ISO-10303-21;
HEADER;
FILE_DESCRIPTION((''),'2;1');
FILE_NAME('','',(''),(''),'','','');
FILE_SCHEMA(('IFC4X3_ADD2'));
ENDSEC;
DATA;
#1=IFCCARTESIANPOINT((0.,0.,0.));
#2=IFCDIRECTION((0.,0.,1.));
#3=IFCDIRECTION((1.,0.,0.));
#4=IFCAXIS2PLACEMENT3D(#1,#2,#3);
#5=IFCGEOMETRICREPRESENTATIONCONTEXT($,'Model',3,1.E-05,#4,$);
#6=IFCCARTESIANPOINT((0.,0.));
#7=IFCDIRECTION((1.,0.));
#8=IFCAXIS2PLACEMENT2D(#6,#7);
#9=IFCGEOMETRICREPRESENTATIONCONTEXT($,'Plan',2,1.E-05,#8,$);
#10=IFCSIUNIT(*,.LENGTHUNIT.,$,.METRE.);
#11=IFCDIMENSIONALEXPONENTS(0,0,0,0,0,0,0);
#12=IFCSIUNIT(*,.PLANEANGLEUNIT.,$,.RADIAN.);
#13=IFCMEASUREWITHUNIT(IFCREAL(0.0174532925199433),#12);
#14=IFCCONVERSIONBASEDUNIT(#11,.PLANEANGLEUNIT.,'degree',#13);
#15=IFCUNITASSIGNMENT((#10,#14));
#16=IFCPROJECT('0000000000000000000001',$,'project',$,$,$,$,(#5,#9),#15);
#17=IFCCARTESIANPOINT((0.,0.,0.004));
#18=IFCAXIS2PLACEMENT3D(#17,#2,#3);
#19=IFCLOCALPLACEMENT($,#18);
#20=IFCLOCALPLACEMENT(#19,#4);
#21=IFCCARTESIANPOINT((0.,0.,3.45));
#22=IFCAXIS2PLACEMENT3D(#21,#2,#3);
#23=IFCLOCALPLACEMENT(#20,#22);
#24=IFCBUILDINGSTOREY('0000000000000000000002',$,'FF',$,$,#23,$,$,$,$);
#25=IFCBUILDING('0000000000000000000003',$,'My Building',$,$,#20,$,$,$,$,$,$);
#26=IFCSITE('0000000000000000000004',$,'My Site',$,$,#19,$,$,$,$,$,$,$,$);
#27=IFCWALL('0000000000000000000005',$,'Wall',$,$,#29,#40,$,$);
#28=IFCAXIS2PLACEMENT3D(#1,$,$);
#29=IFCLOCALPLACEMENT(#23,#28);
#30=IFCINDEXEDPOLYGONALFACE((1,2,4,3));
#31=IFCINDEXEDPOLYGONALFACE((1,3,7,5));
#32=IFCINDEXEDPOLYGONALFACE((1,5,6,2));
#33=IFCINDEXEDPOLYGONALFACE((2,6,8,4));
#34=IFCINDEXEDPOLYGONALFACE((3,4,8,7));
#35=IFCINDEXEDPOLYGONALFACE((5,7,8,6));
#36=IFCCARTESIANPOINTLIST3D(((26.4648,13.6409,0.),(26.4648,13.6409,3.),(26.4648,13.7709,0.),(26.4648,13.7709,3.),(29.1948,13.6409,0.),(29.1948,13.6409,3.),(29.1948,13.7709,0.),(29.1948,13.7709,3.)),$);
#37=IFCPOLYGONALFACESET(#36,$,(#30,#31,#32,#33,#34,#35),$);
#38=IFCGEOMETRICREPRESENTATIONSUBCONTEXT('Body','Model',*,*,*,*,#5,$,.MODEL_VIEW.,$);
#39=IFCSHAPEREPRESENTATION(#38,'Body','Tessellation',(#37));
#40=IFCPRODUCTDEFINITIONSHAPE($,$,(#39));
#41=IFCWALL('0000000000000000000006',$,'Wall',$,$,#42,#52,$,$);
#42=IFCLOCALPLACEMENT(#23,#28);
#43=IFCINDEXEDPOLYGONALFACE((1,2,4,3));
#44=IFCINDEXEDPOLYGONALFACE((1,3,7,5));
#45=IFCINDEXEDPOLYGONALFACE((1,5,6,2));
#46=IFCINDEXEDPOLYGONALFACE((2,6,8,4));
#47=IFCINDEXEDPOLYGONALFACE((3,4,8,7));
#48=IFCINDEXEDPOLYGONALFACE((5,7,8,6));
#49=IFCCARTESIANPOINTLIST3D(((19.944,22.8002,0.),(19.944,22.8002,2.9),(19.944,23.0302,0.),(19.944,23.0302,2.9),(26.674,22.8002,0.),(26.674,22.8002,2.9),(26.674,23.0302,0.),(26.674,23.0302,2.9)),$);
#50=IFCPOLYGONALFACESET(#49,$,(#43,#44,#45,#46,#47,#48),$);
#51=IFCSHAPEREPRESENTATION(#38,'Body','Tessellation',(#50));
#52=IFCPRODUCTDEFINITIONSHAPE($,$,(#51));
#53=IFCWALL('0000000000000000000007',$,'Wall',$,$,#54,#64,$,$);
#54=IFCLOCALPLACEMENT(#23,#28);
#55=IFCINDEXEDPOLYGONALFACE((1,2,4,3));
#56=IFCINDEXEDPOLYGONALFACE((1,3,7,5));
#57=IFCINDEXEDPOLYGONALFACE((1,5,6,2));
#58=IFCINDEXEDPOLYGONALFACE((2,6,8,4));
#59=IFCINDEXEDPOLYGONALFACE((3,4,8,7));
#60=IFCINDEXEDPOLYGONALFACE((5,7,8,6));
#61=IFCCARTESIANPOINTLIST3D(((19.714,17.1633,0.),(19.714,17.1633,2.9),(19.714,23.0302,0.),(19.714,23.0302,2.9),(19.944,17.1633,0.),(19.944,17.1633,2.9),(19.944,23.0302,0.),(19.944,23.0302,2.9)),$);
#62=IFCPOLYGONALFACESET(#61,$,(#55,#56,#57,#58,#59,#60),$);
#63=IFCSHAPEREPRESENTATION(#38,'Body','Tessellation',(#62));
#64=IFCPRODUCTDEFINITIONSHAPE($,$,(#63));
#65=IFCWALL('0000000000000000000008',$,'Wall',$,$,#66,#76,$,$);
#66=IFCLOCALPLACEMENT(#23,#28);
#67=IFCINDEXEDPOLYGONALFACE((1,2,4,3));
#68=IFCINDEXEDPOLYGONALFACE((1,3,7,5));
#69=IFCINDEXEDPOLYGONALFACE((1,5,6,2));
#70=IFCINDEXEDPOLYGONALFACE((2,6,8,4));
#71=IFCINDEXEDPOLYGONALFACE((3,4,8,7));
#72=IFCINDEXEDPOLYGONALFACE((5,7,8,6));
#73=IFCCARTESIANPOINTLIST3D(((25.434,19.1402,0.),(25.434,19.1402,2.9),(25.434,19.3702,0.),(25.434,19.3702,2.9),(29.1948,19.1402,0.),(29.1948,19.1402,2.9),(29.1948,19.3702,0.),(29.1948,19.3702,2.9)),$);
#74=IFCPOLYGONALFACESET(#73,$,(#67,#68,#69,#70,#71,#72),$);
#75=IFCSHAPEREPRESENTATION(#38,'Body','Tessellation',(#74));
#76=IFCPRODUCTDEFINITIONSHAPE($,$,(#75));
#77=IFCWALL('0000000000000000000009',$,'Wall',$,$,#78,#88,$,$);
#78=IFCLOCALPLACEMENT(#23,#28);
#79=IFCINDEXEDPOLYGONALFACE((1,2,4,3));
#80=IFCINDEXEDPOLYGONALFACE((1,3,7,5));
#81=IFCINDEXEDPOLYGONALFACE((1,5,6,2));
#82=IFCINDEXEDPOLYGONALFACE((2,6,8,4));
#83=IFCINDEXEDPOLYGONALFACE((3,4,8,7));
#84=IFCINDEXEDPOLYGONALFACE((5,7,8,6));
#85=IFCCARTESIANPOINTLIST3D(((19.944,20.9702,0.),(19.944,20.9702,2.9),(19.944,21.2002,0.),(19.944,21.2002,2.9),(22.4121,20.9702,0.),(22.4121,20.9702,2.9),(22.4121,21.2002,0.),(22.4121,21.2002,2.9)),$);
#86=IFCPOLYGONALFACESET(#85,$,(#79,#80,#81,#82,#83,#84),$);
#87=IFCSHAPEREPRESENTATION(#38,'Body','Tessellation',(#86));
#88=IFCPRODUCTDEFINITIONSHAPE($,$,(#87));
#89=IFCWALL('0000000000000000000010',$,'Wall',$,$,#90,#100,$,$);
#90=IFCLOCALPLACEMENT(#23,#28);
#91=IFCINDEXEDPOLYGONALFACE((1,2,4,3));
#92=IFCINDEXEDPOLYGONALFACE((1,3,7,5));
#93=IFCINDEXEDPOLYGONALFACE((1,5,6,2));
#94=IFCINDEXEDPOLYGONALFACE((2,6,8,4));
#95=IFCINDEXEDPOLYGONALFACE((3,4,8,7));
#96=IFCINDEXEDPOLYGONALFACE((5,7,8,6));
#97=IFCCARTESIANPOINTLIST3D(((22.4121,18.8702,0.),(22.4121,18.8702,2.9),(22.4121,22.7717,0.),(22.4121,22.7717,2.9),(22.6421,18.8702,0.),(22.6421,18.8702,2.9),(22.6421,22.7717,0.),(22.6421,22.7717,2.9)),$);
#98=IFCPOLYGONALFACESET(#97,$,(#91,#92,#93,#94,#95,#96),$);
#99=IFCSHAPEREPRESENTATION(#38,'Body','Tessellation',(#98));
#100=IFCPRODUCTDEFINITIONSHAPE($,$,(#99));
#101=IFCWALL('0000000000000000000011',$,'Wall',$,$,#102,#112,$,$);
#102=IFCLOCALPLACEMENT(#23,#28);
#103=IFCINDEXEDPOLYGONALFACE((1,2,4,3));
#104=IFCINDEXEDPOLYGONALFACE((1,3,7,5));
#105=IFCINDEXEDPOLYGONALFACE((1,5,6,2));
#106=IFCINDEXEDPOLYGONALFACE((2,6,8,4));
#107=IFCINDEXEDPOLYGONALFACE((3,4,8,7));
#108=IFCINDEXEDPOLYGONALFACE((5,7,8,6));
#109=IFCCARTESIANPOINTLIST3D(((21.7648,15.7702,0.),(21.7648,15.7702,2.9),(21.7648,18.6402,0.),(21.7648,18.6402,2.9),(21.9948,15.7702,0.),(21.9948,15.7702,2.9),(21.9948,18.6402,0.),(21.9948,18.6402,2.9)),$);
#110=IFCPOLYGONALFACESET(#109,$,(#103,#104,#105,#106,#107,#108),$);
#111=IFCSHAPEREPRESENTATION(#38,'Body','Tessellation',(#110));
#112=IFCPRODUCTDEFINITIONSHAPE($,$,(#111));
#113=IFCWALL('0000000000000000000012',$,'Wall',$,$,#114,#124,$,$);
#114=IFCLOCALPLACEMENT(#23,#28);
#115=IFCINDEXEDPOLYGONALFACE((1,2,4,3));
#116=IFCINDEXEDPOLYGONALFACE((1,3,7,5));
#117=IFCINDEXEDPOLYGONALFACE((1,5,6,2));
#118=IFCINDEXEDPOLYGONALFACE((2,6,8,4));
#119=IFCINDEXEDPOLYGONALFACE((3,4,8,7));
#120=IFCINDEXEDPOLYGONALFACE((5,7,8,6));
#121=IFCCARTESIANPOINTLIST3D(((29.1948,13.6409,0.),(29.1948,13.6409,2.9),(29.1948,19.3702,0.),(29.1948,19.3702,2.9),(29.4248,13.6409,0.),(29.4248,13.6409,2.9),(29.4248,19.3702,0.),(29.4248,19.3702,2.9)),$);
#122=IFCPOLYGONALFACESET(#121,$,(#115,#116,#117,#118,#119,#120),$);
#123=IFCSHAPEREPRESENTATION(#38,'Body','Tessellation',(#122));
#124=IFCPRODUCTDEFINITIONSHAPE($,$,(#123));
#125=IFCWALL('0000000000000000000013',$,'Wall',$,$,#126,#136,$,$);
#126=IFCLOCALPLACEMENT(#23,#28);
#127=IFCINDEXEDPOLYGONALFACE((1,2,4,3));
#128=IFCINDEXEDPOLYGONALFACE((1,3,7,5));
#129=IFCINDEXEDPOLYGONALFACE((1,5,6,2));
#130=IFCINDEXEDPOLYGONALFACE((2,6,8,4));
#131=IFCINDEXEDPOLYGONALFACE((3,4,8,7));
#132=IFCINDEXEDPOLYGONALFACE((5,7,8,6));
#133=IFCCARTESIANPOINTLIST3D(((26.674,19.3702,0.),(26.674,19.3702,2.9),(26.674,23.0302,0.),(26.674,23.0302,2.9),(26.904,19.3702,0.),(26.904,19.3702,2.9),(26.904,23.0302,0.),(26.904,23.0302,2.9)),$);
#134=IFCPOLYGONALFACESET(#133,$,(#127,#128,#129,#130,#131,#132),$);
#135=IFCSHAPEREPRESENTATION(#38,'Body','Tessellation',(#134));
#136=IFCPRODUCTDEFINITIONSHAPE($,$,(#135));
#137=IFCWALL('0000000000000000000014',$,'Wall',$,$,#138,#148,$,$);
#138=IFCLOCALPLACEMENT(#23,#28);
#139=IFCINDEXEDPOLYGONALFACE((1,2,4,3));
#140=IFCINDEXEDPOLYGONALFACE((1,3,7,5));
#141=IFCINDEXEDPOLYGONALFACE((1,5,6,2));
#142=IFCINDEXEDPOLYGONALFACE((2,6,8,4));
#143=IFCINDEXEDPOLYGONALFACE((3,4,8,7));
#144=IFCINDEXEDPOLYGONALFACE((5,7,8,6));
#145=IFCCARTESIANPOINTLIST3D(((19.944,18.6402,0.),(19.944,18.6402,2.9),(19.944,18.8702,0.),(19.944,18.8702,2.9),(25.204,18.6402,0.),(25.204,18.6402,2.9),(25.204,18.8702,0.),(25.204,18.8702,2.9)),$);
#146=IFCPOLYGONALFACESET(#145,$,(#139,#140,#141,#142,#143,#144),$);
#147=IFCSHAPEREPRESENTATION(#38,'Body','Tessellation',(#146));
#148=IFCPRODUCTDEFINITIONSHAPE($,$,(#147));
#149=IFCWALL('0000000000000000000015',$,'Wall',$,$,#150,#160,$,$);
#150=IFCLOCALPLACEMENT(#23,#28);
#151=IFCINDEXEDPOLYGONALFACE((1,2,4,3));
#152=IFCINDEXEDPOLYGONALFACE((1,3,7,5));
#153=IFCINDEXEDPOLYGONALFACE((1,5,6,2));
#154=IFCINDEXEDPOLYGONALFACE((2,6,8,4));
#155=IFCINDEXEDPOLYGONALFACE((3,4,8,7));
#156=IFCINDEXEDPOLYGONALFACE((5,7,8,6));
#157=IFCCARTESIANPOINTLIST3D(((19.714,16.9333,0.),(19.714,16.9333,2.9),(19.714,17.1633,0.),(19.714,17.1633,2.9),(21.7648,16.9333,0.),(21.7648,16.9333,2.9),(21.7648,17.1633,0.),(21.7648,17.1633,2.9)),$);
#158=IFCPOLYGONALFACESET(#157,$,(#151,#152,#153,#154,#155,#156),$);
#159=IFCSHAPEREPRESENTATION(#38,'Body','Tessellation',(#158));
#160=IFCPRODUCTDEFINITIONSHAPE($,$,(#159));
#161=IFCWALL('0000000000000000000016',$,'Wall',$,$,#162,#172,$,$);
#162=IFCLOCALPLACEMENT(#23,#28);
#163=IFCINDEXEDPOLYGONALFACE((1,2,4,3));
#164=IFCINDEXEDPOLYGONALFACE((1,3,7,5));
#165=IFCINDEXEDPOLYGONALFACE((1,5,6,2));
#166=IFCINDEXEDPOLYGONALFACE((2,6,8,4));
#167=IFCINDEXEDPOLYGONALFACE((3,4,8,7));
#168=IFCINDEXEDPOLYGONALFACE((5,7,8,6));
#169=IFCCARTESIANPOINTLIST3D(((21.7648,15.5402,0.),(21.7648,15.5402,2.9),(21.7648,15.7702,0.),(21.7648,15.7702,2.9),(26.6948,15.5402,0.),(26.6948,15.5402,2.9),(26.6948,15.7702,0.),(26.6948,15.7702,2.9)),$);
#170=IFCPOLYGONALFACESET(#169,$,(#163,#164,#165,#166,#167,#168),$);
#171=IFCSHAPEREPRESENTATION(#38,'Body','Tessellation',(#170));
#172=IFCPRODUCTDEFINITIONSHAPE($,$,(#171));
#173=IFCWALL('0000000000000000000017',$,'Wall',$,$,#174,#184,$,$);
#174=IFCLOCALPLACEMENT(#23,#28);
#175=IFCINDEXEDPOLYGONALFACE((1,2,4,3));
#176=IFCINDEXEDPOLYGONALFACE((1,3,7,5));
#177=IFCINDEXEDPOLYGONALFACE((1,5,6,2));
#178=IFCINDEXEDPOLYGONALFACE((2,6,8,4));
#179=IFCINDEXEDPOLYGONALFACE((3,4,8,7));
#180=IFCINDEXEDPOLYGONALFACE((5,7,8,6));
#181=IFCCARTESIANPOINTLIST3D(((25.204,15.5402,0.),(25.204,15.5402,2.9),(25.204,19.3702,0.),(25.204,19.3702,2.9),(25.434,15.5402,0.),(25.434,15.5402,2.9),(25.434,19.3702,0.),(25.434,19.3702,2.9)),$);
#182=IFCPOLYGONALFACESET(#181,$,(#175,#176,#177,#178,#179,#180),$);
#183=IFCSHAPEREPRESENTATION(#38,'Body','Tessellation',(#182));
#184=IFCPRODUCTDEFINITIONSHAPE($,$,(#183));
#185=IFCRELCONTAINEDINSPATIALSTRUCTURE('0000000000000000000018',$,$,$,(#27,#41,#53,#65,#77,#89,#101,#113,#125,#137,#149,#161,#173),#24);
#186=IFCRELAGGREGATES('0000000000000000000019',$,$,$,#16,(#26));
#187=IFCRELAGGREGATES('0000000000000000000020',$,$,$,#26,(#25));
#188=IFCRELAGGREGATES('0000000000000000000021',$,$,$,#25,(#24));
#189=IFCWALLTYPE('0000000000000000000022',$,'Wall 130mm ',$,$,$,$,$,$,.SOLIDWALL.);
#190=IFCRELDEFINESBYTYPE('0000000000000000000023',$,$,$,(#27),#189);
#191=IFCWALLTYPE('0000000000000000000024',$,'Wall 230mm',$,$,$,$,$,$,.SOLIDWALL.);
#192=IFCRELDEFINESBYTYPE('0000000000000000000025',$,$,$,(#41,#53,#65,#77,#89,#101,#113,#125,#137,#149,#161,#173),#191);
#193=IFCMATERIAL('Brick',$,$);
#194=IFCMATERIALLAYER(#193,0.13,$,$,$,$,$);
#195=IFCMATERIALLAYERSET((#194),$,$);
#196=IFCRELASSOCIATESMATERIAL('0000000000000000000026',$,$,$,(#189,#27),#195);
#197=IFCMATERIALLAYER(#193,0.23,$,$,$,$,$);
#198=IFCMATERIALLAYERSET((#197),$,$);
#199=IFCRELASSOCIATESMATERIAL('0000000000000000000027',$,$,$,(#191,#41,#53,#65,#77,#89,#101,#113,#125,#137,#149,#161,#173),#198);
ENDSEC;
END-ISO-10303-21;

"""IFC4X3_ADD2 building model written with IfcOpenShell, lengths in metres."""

from ifc_helpers import new_model, entity, si_unit, converted_unit, frame, origin_with_axes, origin_2d_with_axis, place, context, subcontext, project, spatial, indexed_curve, outline, extrude, material, layer, layer_set, layer_usage, type_object, element, save


model = new_model("IFC4X3_ADD2")

# Units and contexts
model_context = context("Model", 3, precision=1e-05, world=origin_with_axes())
plan_context = context("Plan", 2, precision=1e-05, world=origin_2d_with_axis())
body_context = subcontext(model_context, "Body", "Model", "MODEL_VIEW")
ifc_project = project(units=[si_unit("LENGTHUNIT", "METRE"), converted_unit("PLANEANGLEUNIT", "degree", entity("IfcReal", 0.0174532925199433), si_unit("PLANEANGLEUNIT", "RADIAN"), dimensions=[0, 0, 0, 0, 0, 0, 0])], contexts=[model_context, plan_context])

# Site, building, storey
site_placement = place(None, frame((0.0, 0.0, 0.004), z_axis=(0.0, 0.0, 1.0), x_axis=(1.0, 0.0, 0.0)))
site = spatial("IfcSite", under=ifc_project, at=site_placement, Name="My Site")
building_placement = place(site_placement, origin_with_axes())
building = spatial("IfcBuilding", under=site, at=building_placement, Name="My Building")
storey_placement = place(building_placement, frame((0.0, 0.0, 3.45), z_axis=(0.0, 0.0, 1.0), x_axis=(1.0, 0.0, 0.0)))
storey = spatial("IfcBuildingStorey", under=building, at=storey_placement, Name="FF")

# Walls
ifc_material = material(Name="Brick")
ifc_layer_1 = layer(ifc_material, 0.13)
ifc_layer_set_1 = layer_set([ifc_layer_1])
ifc_layer_usage_1 = layer_usage(ifc_layer_set_1, "AXIS2", "POSITIVE", 0.0)
wall_type_1 = type_object("IfcWallType", Name="Wall 130mm ", PredefinedType="SOLIDWALL", material=ifc_layer_set_1)
wall_1_placement = place(storey_placement, frame((29.1948, 13.7709, 0.0), z_axis=(0.0, 0.0, 1.0), x_axis=(-1.0, 0.0, 0.0)))
element("IfcWall", 1, at=wall_1_placement, inside=storey, type_object=wall_type_1, material=ifc_layer_usage_1, Name="Wall", context=body_context, shape_type="SweptSolid", body=[
    extrude(outline(indexed_curve([(0.0, 0.0), (0.0, 0.13), (2.73, 0.13), (2.73, 0.0), (0.0, 0.0)], self_intersect=False)), origin_with_axes(), (0.0, 0.0, 1.0), 3.0),
])
ifc_layer_2 = layer(ifc_material, 0.23)
ifc_layer_set_2 = layer_set([ifc_layer_2])
ifc_layer_usage_2 = layer_usage(ifc_layer_set_2, "AXIS2", "POSITIVE", 0.0)
wall_type_2 = type_object("IfcWallType", Name="Wall 230mm", PredefinedType="SOLIDWALL", material=ifc_layer_set_2)
wall_2_placement = place(storey_placement, frame((26.674, 23.0302, 0.0), z_axis=(0.0, 0.0, 1.0), x_axis=(-1.0, 0.0, 0.0)))
element("IfcWall", 2, at=wall_2_placement, inside=storey, type_object=wall_type_2, material=ifc_layer_usage_2, Name="Wall", context=body_context, shape_type="SweptSolid", body=[
    extrude(outline(indexed_curve([(0.0, 0.0), (0.0, 0.23), (6.73, 0.23), (6.73, 0.0), (0.0, 0.0)], self_intersect=False)), origin_with_axes(), (0.0, 0.0, 1.0), 2.9),
])
ifc_layer_usage_3 = layer_usage(ifc_layer_set_2, "AXIS2", "POSITIVE", 0.0)
wall_3_placement = place(storey_placement, frame((19.944, 17.1633, 0.0), z_axis=(0.0, 0.0, 1.0), x_axis=(0.000001, 1.0, 0.0)))
element("IfcWall", 3, at=wall_3_placement, inside=storey, type_object=wall_type_2, material=ifc_layer_usage_3, Name="Wall", context=body_context, shape_type="SweptSolid", body=[
    extrude(outline(indexed_curve([(0.0, 0.0), (0.0, 0.23), (5.8669, 0.23), (5.8669, 0.0), (0.0, 0.0)], self_intersect=False)), origin_with_axes(), (0.0, 0.0, 1.0), 2.9),
])
ifc_layer_usage_4 = layer_usage(ifc_layer_set_2, "AXIS2", "POSITIVE", 0.0)
wall_4_placement = place(storey_placement, frame((29.1948, 19.3702, 0.0), z_axis=(0.0, 0.0, 1.0), x_axis=(-1.0, 0.0, 0.0)))
element("IfcWall", 4, at=wall_4_placement, inside=storey, type_object=wall_type_2, material=ifc_layer_usage_4, Name="Wall", context=body_context, shape_type="SweptSolid", body=[
    extrude(outline(indexed_curve([(0.0, 0.0), (0.0, 0.23), (3.7608, 0.23), (3.7608, 0.0), (0.0, 0.0)], self_intersect=False)), origin_with_axes(), (0.0, 0.0, 1.0), 2.9),
])
ifc_layer_usage_5 = layer_usage(ifc_layer_set_2, "AXIS2", "POSITIVE", 0.0)
wall_5_placement = place(storey_placement, frame((22.4121, 21.2002, 0.0), z_axis=(0.0, 0.0, 1.0), x_axis=(-1.0, 0.0, 0.0)))
element("IfcWall", 5, at=wall_5_placement, inside=storey, type_object=wall_type_2, material=ifc_layer_usage_5, Name="Wall", context=body_context, shape_type="SweptSolid", body=[
    extrude(outline(indexed_curve([(0.0, 0.0), (0.0, 0.23), (2.4681, 0.23), (2.4681, 0.0), (0.0, 0.0)], self_intersect=False)), origin_with_axes(), (0.0, 0.0, 1.0), 2.9),
])
ifc_layer_usage_6 = layer_usage(ifc_layer_set_2, "AXIS2", "POSITIVE", 0.0)
wall_6_placement = place(storey_placement, frame((22.6421, 18.8702, 0.0), z_axis=(0.0, 0.0, 1.0), x_axis=(0.000001, 1.0, 0.0)))
element("IfcWall", 6, at=wall_6_placement, inside=storey, type_object=wall_type_2, material=ifc_layer_usage_6, Name="Wall", context=body_context, shape_type="SweptSolid", body=[
    extrude(outline(indexed_curve([(0.0, 0.0), (0.0, 0.23), (3.9015, 0.23), (3.9015, 0.0), (0.0, 0.0)], self_intersect=False)), origin_with_axes(), (0.0, 0.0, 1.0), 2.9),
])
ifc_layer_usage_7 = layer_usage(ifc_layer_set_2, "AXIS2", "POSITIVE", 0.0)
wall_7_placement = place(storey_placement, frame((21.9948, 15.7702, 0.0), z_axis=(0.0, 0.0, 1.0), x_axis=(0.000001, 1.0, 0.0)))
element("IfcWall", 7, at=wall_7_placement, inside=storey, type_object=wall_type_2, material=ifc_layer_usage_7, Name="Wall", context=body_context, shape_type="SweptSolid", body=[
    extrude(outline(indexed_curve([(0.0, 0.0), (0.0, 0.23), (2.87, 0.23), (2.87, 0.0), (0.0, 0.0)], self_intersect=False)), origin_with_axes(), (0.0, 0.0, 1.0), 2.9),
])
ifc_layer_usage_8 = layer_usage(ifc_layer_set_2, "AXIS2", "POSITIVE", 0.0)
wall_8_placement = place(storey_placement, frame((29.4248, 13.6409, 0.0), z_axis=(0.0, 0.0, 1.0), x_axis=(0.000001, 1.0, 0.0)))
element("IfcWall", 8, at=wall_8_placement, inside=storey, type_object=wall_type_2, material=ifc_layer_usage_8, Name="Wall", context=body_context, shape_type="SweptSolid", body=[
    extrude(outline(indexed_curve([(0.0, 0.0), (0.0, 0.23), (5.7293, 0.23), (5.7293, 0.0), (0.0, 0.0)], self_intersect=False)), origin_with_axes(), (0.0, 0.0, 1.0), 2.9),
])
ifc_layer_usage_9 = layer_usage(ifc_layer_set_2, "AXIS2", "POSITIVE", 0.0)
wall_9_placement = place(storey_placement, frame((26.904, 19.3702, 0.0), z_axis=(0.0, 0.0, 1.0), x_axis=(0.000001, 1.0, 0.0)))
element("IfcWall", 9, at=wall_9_placement, inside=storey, type_object=wall_type_2, material=ifc_layer_usage_9, Name="Wall", context=body_context, shape_type="SweptSolid", body=[
    extrude(outline(indexed_curve([(0.0, 0.0), (0.0, 0.23), (3.66, 0.23), (3.66, 0.0), (0.0, 0.0)], self_intersect=False)), origin_with_axes(), (0.0, 0.0, 1.0), 2.9),
])
ifc_layer_usage_10 = layer_usage(ifc_layer_set_2, "AXIS2", "POSITIVE", 0.0)
wall_10_placement = place(storey_placement, frame((25.204, 18.8702, 0.0), z_axis=(0.0, 0.0, 1.0), x_axis=(-1.0, 0.0, 0.0)))
element("IfcWall", 10, at=wall_10_placement, inside=storey, type_object=wall_type_2, material=ifc_layer_usage_10, Name="Wall", context=body_context, shape_type="SweptSolid", body=[
    extrude(outline(indexed_curve([(0.0, 0.0), (0.0, 0.23), (5.26, 0.23), (5.26, 0.0), (0.0, 0.0)], self_intersect=False)), origin_with_axes(), (0.0, 0.0, 1.0), 2.9),
])
ifc_layer_usage_11 = layer_usage(ifc_layer_set_2, "AXIS2", "POSITIVE", 0.0)
wall_11_placement = place(storey_placement, frame((21.7648, 17.1633, 0.0), z_axis=(0.0, 0.0, 1.0), x_axis=(-1.0, 0.0, 0.0)))
element("IfcWall", 11, at=wall_11_placement, inside=storey, type_object=wall_type_2, material=ifc_layer_usage_11, Name="Wall", context=body_context, shape_type="SweptSolid", body=[
    extrude(outline(indexed_curve([(0.0, 0.0), (0.0, 0.23), (2.0508, 0.23), (2.0508, 0.0), (0.0, 0.0)], self_intersect=False)), origin_with_axes(), (0.0, 0.0, 1.0), 2.9),
])
ifc_layer_usage_12 = layer_usage(ifc_layer_set_2, "AXIS2", "POSITIVE", 0.0)
wall_12_placement = place(storey_placement, frame((26.6948, 15.7702, 0.0), z_axis=(0.0, 0.0, 1.0), x_axis=(-1.0, 0.0, 0.0)))
element("IfcWall", 12, at=wall_12_placement, inside=storey, type_object=wall_type_2, material=ifc_layer_usage_12, Name="Wall", context=body_context, shape_type="SweptSolid", body=[
    extrude(outline(indexed_curve([(0.0, 0.0), (0.0, 0.23), (4.93, 0.23), (4.93, 0.0), (0.0, 0.0)], self_intersect=False)), origin_with_axes(), (0.0, 0.0, 1.0), 2.9),
])
ifc_layer_usage_13 = layer_usage(ifc_layer_set_2, "AXIS2", "POSITIVE", 0.0)
wall_13_placement = place(storey_placement, frame((25.434, 15.5402, 0.0), z_axis=(0.0, 0.0, 1.0), x_axis=(0.000001, 1.0, 0.0)))
element("IfcWall", 13, at=wall_13_placement, inside=storey, type_object=wall_type_2, material=ifc_layer_usage_13, Name="Wall", context=body_context, shape_type="SweptSolid", body=[
    extrude(outline(indexed_curve([(0.0, 0.0), (0.0, 0.23), (3.83, 0.23), (3.83, 0.0), (0.0, 0.0)], self_intersect=False)), origin_with_axes(), (0.0, 0.0, 1.0), 2.9),
])

save(model, "model.ifc")
